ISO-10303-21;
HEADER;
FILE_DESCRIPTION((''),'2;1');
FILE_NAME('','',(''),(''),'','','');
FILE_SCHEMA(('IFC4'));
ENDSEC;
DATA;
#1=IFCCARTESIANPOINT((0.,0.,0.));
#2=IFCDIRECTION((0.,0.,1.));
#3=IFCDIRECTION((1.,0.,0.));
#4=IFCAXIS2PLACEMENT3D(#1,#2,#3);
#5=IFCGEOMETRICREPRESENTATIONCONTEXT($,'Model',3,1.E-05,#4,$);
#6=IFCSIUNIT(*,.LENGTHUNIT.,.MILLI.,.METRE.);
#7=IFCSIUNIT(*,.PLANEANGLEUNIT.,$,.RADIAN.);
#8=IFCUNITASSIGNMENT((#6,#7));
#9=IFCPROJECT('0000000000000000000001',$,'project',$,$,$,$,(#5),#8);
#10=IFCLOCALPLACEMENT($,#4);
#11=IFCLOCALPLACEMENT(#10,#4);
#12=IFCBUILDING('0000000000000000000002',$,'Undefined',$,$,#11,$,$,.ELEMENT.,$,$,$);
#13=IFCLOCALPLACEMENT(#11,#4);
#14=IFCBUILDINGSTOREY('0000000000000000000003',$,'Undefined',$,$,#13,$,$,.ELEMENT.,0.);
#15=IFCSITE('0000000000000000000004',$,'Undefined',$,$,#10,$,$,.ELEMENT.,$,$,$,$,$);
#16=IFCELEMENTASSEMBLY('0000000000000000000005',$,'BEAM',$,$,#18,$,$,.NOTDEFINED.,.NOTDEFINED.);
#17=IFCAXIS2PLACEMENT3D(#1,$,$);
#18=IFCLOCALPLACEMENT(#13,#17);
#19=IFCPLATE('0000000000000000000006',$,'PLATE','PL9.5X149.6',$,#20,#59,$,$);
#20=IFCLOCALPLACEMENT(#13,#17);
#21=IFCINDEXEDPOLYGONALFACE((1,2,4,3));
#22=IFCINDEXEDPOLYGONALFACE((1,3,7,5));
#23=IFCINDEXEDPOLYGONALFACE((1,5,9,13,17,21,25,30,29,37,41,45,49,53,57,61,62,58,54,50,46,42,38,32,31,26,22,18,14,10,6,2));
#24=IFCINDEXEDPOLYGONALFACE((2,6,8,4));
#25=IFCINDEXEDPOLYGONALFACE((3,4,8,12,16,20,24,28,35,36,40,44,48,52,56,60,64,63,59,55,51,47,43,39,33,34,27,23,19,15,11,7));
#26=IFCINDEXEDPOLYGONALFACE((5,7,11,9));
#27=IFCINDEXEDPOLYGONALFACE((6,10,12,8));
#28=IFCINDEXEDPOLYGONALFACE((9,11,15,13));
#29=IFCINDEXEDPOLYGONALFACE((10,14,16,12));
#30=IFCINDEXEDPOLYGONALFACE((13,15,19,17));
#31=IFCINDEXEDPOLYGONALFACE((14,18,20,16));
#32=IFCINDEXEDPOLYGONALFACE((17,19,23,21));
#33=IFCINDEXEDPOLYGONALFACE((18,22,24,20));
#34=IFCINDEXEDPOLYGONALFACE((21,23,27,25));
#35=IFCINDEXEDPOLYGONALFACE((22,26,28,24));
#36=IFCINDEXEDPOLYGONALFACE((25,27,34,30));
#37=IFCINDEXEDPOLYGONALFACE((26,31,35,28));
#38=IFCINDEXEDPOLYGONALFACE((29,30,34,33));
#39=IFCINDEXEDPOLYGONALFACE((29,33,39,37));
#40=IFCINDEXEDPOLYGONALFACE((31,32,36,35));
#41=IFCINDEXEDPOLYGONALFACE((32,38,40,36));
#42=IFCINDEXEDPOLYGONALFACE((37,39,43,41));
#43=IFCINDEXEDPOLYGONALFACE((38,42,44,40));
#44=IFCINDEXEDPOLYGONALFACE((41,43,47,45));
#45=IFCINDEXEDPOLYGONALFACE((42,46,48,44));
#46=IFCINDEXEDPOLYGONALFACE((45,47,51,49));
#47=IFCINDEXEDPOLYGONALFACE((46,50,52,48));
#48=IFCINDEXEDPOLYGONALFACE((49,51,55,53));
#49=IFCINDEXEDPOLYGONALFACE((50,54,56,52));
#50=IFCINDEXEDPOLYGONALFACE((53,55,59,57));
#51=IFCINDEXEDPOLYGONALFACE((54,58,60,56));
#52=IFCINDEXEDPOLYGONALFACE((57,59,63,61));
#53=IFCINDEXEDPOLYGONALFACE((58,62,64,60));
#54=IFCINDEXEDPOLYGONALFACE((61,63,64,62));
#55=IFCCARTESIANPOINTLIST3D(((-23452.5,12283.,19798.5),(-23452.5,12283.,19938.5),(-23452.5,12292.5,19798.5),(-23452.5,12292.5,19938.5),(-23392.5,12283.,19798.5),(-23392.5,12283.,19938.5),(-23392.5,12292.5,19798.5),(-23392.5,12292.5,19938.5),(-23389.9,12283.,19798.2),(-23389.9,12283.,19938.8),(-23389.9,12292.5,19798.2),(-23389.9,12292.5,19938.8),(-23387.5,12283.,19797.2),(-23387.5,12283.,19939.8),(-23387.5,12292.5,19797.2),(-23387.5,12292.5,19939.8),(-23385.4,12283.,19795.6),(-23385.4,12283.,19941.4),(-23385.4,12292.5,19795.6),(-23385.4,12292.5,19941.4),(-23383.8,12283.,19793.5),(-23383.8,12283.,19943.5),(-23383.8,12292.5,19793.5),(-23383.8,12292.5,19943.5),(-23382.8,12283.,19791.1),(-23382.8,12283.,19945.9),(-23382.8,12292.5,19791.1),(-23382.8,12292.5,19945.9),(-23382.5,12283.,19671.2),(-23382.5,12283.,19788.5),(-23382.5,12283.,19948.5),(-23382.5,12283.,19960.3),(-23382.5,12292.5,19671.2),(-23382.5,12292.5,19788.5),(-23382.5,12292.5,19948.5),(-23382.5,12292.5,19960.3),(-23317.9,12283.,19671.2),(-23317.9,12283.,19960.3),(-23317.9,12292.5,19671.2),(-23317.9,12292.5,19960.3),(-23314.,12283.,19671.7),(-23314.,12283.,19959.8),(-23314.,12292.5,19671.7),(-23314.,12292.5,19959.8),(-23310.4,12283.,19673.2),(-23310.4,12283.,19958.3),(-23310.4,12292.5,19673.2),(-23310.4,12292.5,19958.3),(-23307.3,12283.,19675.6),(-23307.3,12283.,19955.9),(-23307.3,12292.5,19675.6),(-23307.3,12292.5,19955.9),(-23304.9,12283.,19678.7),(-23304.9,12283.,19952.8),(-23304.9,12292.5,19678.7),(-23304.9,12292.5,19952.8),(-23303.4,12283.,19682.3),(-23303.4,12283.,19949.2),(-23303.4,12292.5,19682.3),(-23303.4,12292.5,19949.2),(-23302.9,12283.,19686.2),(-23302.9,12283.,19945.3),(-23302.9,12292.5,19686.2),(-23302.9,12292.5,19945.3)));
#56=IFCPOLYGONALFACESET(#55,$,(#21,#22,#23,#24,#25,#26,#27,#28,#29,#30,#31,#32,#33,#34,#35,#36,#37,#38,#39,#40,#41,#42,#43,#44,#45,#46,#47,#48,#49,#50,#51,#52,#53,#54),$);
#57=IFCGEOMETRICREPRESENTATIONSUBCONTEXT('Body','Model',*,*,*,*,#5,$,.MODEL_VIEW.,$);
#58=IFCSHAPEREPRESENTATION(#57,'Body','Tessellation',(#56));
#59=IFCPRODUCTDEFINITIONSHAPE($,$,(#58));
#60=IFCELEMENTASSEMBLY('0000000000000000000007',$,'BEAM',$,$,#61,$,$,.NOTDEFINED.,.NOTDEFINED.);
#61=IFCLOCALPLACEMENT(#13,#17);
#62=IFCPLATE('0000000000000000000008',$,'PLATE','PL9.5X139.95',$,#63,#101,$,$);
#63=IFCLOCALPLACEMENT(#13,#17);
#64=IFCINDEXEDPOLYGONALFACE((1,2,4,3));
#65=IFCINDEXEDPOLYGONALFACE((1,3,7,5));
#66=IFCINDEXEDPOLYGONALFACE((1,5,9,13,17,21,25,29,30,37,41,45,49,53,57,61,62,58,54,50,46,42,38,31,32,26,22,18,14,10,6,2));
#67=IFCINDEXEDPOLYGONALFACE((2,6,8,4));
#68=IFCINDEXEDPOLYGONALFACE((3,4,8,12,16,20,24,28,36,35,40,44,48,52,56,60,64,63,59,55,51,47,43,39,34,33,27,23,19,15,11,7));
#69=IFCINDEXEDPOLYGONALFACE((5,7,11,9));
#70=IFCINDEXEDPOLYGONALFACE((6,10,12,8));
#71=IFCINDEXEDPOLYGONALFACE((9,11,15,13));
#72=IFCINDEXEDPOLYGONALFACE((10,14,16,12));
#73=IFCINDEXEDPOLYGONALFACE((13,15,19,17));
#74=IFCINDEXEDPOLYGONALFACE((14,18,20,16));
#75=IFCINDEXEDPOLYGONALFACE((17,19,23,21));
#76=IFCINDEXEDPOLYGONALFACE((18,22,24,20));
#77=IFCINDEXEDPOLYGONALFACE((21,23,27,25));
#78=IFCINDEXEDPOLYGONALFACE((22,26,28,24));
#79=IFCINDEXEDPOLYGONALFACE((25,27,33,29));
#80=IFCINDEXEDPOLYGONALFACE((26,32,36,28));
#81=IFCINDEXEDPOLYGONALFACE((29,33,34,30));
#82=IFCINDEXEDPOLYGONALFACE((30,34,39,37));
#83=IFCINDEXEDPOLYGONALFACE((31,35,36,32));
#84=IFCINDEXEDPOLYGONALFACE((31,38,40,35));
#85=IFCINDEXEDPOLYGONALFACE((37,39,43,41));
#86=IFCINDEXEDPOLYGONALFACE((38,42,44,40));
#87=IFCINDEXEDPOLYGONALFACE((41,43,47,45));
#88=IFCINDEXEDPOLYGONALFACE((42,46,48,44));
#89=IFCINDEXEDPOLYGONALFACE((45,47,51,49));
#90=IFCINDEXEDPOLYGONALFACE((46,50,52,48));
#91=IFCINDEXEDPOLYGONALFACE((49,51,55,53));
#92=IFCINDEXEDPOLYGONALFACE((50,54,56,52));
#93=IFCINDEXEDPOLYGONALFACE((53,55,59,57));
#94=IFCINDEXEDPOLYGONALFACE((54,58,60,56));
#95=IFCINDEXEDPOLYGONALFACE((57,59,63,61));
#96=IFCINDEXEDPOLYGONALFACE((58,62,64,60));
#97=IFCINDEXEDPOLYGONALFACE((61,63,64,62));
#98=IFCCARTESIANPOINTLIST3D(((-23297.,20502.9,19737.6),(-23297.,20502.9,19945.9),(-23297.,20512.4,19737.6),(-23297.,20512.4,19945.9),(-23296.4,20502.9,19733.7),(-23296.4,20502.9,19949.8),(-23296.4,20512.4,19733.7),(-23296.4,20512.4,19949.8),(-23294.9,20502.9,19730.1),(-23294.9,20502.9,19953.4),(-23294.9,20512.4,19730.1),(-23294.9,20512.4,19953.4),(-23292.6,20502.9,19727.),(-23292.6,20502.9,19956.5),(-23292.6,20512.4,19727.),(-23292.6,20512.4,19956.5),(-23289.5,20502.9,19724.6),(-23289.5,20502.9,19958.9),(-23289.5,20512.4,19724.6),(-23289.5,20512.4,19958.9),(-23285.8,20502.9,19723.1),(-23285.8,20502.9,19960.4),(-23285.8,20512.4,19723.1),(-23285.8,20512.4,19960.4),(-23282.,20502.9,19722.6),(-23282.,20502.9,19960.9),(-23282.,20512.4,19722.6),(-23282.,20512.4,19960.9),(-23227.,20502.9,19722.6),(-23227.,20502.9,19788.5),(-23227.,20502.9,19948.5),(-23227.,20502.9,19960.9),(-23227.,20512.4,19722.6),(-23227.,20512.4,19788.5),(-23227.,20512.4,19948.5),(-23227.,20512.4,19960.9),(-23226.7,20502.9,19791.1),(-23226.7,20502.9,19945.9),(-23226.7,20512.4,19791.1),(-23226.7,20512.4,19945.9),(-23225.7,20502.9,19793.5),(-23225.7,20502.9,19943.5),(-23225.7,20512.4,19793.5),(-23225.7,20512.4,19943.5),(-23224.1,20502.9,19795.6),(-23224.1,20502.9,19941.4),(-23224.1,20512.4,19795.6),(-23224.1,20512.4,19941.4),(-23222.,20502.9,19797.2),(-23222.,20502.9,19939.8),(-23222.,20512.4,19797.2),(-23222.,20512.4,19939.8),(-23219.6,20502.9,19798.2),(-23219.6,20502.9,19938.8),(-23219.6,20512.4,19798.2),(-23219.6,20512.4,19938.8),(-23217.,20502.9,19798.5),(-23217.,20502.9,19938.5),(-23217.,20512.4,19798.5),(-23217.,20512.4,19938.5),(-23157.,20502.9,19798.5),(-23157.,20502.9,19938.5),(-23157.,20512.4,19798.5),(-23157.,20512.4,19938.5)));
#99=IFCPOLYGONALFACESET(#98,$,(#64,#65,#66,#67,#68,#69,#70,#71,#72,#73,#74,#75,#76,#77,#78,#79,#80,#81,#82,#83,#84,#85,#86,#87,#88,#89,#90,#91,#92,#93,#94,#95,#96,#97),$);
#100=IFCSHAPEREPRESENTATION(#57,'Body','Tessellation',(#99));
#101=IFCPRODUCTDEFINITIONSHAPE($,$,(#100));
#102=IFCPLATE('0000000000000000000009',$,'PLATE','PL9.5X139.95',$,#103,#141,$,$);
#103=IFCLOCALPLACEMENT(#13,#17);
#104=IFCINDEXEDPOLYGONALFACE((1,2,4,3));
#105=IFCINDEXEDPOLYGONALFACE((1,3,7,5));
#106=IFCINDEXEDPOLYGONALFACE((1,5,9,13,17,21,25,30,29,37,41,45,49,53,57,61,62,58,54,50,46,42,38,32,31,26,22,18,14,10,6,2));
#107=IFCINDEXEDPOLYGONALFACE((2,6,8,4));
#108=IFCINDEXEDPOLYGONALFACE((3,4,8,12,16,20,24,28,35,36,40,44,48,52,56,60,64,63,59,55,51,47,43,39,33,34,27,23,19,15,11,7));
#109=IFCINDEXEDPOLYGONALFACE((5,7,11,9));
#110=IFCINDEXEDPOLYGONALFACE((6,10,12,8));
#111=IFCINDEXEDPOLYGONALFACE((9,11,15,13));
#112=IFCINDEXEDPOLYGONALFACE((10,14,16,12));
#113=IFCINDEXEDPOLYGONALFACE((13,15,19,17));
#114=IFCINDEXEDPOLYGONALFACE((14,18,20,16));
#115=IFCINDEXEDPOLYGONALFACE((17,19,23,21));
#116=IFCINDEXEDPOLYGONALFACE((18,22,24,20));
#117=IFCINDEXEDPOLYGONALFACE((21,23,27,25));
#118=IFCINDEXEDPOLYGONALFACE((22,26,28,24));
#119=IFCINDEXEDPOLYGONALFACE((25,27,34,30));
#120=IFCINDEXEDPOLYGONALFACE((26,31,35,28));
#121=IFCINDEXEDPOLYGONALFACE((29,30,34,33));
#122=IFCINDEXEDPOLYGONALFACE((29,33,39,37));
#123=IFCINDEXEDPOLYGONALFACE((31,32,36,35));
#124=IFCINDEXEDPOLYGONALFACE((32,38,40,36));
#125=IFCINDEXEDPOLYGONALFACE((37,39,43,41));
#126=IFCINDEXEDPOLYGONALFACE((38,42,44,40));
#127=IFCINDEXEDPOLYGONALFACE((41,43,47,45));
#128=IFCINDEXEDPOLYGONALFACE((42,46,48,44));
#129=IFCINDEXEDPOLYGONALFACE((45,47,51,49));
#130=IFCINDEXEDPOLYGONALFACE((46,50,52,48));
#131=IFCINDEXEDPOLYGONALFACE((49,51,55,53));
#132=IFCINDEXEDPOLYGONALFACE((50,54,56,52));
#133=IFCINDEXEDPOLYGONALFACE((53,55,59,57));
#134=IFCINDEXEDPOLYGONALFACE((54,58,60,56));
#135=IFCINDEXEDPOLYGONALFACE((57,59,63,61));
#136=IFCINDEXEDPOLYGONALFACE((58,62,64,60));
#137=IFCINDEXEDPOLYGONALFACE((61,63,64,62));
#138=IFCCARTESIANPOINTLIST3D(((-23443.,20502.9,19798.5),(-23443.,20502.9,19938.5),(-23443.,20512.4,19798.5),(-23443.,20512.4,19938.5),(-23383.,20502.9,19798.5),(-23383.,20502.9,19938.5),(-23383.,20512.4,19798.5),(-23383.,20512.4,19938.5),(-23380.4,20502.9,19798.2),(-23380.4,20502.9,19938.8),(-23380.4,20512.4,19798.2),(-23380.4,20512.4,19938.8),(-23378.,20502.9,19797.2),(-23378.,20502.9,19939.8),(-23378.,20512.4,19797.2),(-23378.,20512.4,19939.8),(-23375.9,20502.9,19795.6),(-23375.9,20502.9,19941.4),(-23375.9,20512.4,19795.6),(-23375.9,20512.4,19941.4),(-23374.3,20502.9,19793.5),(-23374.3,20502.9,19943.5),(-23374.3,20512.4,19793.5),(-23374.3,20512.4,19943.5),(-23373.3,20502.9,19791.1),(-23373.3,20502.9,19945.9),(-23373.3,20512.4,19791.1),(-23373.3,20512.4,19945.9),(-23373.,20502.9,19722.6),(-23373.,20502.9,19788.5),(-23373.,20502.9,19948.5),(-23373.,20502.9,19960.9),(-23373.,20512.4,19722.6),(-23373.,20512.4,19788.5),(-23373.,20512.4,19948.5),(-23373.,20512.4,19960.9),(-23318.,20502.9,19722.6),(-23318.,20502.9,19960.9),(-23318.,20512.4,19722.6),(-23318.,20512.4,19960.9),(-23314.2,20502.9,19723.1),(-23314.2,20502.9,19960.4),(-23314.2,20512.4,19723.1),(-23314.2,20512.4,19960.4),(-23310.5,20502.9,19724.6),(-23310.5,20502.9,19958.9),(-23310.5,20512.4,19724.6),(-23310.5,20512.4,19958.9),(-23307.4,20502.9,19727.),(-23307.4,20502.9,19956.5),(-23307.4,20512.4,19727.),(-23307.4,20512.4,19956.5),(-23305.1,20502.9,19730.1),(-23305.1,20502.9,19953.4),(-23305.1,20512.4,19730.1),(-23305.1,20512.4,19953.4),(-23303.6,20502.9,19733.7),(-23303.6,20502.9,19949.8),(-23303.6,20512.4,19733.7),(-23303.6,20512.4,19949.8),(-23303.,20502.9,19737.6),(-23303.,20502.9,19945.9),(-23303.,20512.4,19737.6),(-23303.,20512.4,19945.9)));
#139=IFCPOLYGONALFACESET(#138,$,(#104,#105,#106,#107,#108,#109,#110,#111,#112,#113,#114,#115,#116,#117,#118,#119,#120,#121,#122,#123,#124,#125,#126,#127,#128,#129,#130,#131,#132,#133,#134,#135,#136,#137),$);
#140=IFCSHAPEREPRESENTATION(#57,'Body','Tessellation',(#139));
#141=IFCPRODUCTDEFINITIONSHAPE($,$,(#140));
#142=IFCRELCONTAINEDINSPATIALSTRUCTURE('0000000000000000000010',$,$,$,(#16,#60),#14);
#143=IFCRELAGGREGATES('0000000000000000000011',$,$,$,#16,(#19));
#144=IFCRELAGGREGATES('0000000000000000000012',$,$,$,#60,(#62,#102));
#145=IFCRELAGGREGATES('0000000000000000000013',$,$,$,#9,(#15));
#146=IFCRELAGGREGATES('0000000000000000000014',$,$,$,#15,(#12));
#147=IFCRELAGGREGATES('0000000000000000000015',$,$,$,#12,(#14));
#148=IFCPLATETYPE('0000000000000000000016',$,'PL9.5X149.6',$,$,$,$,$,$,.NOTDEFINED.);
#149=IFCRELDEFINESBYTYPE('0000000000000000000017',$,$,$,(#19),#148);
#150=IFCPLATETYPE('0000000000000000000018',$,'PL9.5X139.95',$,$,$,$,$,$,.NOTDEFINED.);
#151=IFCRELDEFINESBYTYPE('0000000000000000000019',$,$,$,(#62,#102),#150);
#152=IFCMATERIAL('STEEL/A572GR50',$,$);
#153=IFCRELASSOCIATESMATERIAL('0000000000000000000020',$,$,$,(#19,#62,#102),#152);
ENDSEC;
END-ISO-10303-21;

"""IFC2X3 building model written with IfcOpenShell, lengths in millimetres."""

from ifc_helpers import new_model, si_unit, frame, frame_2d, origin_with_axes, place, context, subcontext, project, spatial, polyline, circle_curve, parameter, trimmed, segment, composite_curve, outline, extrude, material, type_object, element, aggregate, save


model = new_model("IFC2X3")

# Units and contexts
model_context = context("Model", 3, precision=1e-05, world=origin_with_axes())
body_context = subcontext(model_context, "Body", "Model", "MODEL_VIEW")
ifc_project = project(units=[si_unit("LENGTHUNIT", "METRE", prefix="MILLI"), si_unit("PLANEANGLEUNIT", "RADIAN")], contexts=[model_context])

# Site, building, storey
site_placement = place(None, origin_with_axes())
site = spatial("IfcSite", under=ifc_project, at=site_placement, Name="Undefined", CompositionType="ELEMENT")
building_placement = place(site_placement, origin_with_axes())
building = spatial("IfcBuilding", under=site, at=building_placement, Name="Undefined", CompositionType="ELEMENT")
storey_placement = place(building_placement, origin_with_axes())
storey = spatial("IfcBuildingStorey", under=building, at=storey_placement, Name="Undefined", CompositionType="ELEMENT", Elevation=0.0)

# Shared definitions
ifc_material_1 = material(Name="STEEL/A572GR50")

# Element assembly, plate
assembly_1_placement = place(storey_placement, origin_with_axes())
assembly_1 = element("IfcElementAssembly", 1, at=assembly_1_placement, inside=storey, Name="BEAM", AssemblyPlace="NOTDEFINED", PredefinedType="NOTDEFINED")
plate_type_1 = type_object("IfcPlateType", Name="PL9.5X149.6", PredefinedType="NOTDEFINED")
plate_1_placement = place(assembly_1_placement, frame((-23302.9, 12287.7, 19960.3), z_axis=(0.0, 1.0, 0.0), x_axis=(0.0, 0.0, -1.0)))
plate_1 = element("IfcPlate", 2, at=plate_1_placement, type_object=plate_type_1, material=ifc_material_1, Name="PLATE", Description="PL9.5X149.6", context=body_context, shape_type="SweptSolid", body=[
    extrude(outline(composite_curve([segment(trimmed(circle_curve(frame_2d((15.0, 15.0), x_axis=(-1.0, 0.0)), 15.0), [parameter(0.0)], [parameter(1.570796)], True, "PARAMETER"), True, "CONTINUOUS"), segment(polyline([(15.0, 0.0), (274.1, 0.0)]), True, "CONTINUOUS"), segment(trimmed(circle_curve(frame_2d((274.1, 15.0), x_axis=(0.0, -1.0)), 15.0), [parameter(0.0)], [parameter(1.570796)], True, "PARAMETER"), True, "CONTINUOUS"), segment(polyline([(289.1, 15.0), (289.1, 79.6), (171.8, 79.6)]), True, "CONTINUOUS"), segment(trimmed(circle_curve(frame_2d((171.8, 89.6), x_axis=(0.0, -1.0)), 10.0), [parameter(0.0)], [parameter(4.712389)], False, "PARAMETER"), True, "CONTINUOUS"), segment(polyline([(161.8, 89.6), (161.8, 149.6), (21.8, 149.6), (21.8, 89.6)]), True, "CONTINUOUS"), segment(trimmed(circle_curve(frame_2d((11.8, 89.6), x_axis=(1.0, 0.0)), 10.0), [parameter(0.0)], [parameter(4.712389)], False, "PARAMETER"), True, "CONTINUOUS"), segment(polyline([(11.8, 79.6), (0.0, 79.6), (0.0, 15.0)]), True, "CONTINUOUS")], self_intersect=True)), frame((0.0, 0.0, -4.8), z_axis=(0.0, 0.0, 1.0), x_axis=(1.0, 0.0, 0.0)), (0.0, 0.0, 1.0), 9.5),
])

# Element assembly, plates
assembly_2_placement = place(storey_placement, origin_with_axes())
assembly_2 = element("IfcElementAssembly", 3, at=assembly_2_placement, inside=storey, Name="BEAM", AssemblyPlace="NOTDEFINED", PredefinedType="NOTDEFINED")
plate_type_2 = type_object("IfcPlateType", Name="PL9.5X139.95", PredefinedType="NOTDEFINED")
plate_2_placement = place(assembly_2_placement, frame((-23297.0, 20507.7, 19960.9), z_axis=(0.0, -1.0, 0.0), x_axis=(0.0, 0.0, -1.0)))
plate_2 = element("IfcPlate", 4, at=plate_2_placement, type_object=plate_type_2, material=ifc_material_1, Name="PLATE", Description="PL9.5X139.95", context=body_context, shape_type="SweptSolid", body=[
    extrude(outline(composite_curve([segment(trimmed(circle_curve(frame_2d((15.0, 15.0), x_axis=(-1.0, 0.0)), 15.0), [parameter(0.0)], [parameter(1.570796)], True, "PARAMETER"), True, "CONTINUOUS"), segment(polyline([(15.0, 0.0), (223.3, 0.0)]), True, "CONTINUOUS"), segment(trimmed(circle_curve(frame_2d((223.3, 15.0), x_axis=(0.0, -1.0)), 15.0), [parameter(0.0)], [parameter(1.570796)], True, "PARAMETER"), True, "CONTINUOUS"), segment(polyline([(238.3, 15.0), (238.3, 69.9), (172.4, 69.9)]), True, "CONTINUOUS"), segment(trimmed(circle_curve(frame_2d((172.4, 79.9), x_axis=(0.0, -1.0)), 10.0), [parameter(0.0)], [parameter(4.712389)], False, "PARAMETER"), True, "CONTINUOUS"), segment(polyline([(162.4, 79.9), (162.4, 139.9), (22.4, 139.9), (22.4, 79.9)]), True, "CONTINUOUS"), segment(trimmed(circle_curve(frame_2d((12.4, 79.9), x_axis=(1.0, 0.0)), 10.0), [parameter(0.0)], [parameter(4.712389)], False, "PARAMETER"), True, "CONTINUOUS"), segment(polyline([(12.4, 69.9), (0.0, 69.9), (0.0, 15.0)]), True, "CONTINUOUS")], self_intersect=True)), frame((0.0, 0.0, -4.8), z_axis=(0.0, 0.0, 1.0), x_axis=(1.0, 0.0, 0.0)), (0.0, 0.0, 1.0), 9.5),
])
plate_3_placement = place(assembly_2_placement, frame((-23303.0, 20507.7, 19960.9), z_axis=(0.0, 1.0, 0.0), x_axis=(0.0, 0.0, -1.0)))
plate_3 = element("IfcPlate", 5, at=plate_3_placement, type_object=plate_type_2, material=ifc_material_1, Name="PLATE", Description="PL9.5X139.95", context=body_context, shape_type="SweptSolid", body=[
    extrude(outline(composite_curve([segment(trimmed(circle_curve(frame_2d((15.0, 15.0), x_axis=(-1.0, 0.0)), 15.0), [parameter(0.0)], [parameter(1.570796)], True, "PARAMETER"), True, "CONTINUOUS"), segment(polyline([(15.0, 0.0), (223.3, 0.0)]), True, "CONTINUOUS"), segment(trimmed(circle_curve(frame_2d((223.3, 15.0), x_axis=(0.0, -1.0)), 15.0), [parameter(0.0)], [parameter(1.570796)], True, "PARAMETER"), True, "CONTINUOUS"), segment(polyline([(238.3, 15.0), (238.3, 69.9), (172.4, 69.9)]), True, "CONTINUOUS"), segment(trimmed(circle_curve(frame_2d((172.4, 79.9), x_axis=(0.0, -1.0)), 10.0), [parameter(0.0)], [parameter(4.712389)], False, "PARAMETER"), True, "CONTINUOUS"), segment(polyline([(162.4, 79.9), (162.4, 139.9), (22.4, 139.9), (22.4, 79.9)]), True, "CONTINUOUS"), segment(trimmed(circle_curve(frame_2d((12.4, 79.9), x_axis=(1.0, 0.0)), 10.0), [parameter(0.0)], [parameter(4.712389)], False, "PARAMETER"), True, "CONTINUOUS"), segment(polyline([(12.4, 69.9), (0.0, 69.9), (0.0, 15.0)]), True, "CONTINUOUS")], self_intersect=True)), frame((0.0, 0.0, -4.8), z_axis=(0.0, 0.0, 1.0), x_axis=(1.0, 0.0, 0.0)), (0.0, 0.0, 1.0), 9.5),
])

aggregate(assembly_1, [plate_1])
aggregate(assembly_2, [plate_2, plate_3])

save(model, "model.ifc")
